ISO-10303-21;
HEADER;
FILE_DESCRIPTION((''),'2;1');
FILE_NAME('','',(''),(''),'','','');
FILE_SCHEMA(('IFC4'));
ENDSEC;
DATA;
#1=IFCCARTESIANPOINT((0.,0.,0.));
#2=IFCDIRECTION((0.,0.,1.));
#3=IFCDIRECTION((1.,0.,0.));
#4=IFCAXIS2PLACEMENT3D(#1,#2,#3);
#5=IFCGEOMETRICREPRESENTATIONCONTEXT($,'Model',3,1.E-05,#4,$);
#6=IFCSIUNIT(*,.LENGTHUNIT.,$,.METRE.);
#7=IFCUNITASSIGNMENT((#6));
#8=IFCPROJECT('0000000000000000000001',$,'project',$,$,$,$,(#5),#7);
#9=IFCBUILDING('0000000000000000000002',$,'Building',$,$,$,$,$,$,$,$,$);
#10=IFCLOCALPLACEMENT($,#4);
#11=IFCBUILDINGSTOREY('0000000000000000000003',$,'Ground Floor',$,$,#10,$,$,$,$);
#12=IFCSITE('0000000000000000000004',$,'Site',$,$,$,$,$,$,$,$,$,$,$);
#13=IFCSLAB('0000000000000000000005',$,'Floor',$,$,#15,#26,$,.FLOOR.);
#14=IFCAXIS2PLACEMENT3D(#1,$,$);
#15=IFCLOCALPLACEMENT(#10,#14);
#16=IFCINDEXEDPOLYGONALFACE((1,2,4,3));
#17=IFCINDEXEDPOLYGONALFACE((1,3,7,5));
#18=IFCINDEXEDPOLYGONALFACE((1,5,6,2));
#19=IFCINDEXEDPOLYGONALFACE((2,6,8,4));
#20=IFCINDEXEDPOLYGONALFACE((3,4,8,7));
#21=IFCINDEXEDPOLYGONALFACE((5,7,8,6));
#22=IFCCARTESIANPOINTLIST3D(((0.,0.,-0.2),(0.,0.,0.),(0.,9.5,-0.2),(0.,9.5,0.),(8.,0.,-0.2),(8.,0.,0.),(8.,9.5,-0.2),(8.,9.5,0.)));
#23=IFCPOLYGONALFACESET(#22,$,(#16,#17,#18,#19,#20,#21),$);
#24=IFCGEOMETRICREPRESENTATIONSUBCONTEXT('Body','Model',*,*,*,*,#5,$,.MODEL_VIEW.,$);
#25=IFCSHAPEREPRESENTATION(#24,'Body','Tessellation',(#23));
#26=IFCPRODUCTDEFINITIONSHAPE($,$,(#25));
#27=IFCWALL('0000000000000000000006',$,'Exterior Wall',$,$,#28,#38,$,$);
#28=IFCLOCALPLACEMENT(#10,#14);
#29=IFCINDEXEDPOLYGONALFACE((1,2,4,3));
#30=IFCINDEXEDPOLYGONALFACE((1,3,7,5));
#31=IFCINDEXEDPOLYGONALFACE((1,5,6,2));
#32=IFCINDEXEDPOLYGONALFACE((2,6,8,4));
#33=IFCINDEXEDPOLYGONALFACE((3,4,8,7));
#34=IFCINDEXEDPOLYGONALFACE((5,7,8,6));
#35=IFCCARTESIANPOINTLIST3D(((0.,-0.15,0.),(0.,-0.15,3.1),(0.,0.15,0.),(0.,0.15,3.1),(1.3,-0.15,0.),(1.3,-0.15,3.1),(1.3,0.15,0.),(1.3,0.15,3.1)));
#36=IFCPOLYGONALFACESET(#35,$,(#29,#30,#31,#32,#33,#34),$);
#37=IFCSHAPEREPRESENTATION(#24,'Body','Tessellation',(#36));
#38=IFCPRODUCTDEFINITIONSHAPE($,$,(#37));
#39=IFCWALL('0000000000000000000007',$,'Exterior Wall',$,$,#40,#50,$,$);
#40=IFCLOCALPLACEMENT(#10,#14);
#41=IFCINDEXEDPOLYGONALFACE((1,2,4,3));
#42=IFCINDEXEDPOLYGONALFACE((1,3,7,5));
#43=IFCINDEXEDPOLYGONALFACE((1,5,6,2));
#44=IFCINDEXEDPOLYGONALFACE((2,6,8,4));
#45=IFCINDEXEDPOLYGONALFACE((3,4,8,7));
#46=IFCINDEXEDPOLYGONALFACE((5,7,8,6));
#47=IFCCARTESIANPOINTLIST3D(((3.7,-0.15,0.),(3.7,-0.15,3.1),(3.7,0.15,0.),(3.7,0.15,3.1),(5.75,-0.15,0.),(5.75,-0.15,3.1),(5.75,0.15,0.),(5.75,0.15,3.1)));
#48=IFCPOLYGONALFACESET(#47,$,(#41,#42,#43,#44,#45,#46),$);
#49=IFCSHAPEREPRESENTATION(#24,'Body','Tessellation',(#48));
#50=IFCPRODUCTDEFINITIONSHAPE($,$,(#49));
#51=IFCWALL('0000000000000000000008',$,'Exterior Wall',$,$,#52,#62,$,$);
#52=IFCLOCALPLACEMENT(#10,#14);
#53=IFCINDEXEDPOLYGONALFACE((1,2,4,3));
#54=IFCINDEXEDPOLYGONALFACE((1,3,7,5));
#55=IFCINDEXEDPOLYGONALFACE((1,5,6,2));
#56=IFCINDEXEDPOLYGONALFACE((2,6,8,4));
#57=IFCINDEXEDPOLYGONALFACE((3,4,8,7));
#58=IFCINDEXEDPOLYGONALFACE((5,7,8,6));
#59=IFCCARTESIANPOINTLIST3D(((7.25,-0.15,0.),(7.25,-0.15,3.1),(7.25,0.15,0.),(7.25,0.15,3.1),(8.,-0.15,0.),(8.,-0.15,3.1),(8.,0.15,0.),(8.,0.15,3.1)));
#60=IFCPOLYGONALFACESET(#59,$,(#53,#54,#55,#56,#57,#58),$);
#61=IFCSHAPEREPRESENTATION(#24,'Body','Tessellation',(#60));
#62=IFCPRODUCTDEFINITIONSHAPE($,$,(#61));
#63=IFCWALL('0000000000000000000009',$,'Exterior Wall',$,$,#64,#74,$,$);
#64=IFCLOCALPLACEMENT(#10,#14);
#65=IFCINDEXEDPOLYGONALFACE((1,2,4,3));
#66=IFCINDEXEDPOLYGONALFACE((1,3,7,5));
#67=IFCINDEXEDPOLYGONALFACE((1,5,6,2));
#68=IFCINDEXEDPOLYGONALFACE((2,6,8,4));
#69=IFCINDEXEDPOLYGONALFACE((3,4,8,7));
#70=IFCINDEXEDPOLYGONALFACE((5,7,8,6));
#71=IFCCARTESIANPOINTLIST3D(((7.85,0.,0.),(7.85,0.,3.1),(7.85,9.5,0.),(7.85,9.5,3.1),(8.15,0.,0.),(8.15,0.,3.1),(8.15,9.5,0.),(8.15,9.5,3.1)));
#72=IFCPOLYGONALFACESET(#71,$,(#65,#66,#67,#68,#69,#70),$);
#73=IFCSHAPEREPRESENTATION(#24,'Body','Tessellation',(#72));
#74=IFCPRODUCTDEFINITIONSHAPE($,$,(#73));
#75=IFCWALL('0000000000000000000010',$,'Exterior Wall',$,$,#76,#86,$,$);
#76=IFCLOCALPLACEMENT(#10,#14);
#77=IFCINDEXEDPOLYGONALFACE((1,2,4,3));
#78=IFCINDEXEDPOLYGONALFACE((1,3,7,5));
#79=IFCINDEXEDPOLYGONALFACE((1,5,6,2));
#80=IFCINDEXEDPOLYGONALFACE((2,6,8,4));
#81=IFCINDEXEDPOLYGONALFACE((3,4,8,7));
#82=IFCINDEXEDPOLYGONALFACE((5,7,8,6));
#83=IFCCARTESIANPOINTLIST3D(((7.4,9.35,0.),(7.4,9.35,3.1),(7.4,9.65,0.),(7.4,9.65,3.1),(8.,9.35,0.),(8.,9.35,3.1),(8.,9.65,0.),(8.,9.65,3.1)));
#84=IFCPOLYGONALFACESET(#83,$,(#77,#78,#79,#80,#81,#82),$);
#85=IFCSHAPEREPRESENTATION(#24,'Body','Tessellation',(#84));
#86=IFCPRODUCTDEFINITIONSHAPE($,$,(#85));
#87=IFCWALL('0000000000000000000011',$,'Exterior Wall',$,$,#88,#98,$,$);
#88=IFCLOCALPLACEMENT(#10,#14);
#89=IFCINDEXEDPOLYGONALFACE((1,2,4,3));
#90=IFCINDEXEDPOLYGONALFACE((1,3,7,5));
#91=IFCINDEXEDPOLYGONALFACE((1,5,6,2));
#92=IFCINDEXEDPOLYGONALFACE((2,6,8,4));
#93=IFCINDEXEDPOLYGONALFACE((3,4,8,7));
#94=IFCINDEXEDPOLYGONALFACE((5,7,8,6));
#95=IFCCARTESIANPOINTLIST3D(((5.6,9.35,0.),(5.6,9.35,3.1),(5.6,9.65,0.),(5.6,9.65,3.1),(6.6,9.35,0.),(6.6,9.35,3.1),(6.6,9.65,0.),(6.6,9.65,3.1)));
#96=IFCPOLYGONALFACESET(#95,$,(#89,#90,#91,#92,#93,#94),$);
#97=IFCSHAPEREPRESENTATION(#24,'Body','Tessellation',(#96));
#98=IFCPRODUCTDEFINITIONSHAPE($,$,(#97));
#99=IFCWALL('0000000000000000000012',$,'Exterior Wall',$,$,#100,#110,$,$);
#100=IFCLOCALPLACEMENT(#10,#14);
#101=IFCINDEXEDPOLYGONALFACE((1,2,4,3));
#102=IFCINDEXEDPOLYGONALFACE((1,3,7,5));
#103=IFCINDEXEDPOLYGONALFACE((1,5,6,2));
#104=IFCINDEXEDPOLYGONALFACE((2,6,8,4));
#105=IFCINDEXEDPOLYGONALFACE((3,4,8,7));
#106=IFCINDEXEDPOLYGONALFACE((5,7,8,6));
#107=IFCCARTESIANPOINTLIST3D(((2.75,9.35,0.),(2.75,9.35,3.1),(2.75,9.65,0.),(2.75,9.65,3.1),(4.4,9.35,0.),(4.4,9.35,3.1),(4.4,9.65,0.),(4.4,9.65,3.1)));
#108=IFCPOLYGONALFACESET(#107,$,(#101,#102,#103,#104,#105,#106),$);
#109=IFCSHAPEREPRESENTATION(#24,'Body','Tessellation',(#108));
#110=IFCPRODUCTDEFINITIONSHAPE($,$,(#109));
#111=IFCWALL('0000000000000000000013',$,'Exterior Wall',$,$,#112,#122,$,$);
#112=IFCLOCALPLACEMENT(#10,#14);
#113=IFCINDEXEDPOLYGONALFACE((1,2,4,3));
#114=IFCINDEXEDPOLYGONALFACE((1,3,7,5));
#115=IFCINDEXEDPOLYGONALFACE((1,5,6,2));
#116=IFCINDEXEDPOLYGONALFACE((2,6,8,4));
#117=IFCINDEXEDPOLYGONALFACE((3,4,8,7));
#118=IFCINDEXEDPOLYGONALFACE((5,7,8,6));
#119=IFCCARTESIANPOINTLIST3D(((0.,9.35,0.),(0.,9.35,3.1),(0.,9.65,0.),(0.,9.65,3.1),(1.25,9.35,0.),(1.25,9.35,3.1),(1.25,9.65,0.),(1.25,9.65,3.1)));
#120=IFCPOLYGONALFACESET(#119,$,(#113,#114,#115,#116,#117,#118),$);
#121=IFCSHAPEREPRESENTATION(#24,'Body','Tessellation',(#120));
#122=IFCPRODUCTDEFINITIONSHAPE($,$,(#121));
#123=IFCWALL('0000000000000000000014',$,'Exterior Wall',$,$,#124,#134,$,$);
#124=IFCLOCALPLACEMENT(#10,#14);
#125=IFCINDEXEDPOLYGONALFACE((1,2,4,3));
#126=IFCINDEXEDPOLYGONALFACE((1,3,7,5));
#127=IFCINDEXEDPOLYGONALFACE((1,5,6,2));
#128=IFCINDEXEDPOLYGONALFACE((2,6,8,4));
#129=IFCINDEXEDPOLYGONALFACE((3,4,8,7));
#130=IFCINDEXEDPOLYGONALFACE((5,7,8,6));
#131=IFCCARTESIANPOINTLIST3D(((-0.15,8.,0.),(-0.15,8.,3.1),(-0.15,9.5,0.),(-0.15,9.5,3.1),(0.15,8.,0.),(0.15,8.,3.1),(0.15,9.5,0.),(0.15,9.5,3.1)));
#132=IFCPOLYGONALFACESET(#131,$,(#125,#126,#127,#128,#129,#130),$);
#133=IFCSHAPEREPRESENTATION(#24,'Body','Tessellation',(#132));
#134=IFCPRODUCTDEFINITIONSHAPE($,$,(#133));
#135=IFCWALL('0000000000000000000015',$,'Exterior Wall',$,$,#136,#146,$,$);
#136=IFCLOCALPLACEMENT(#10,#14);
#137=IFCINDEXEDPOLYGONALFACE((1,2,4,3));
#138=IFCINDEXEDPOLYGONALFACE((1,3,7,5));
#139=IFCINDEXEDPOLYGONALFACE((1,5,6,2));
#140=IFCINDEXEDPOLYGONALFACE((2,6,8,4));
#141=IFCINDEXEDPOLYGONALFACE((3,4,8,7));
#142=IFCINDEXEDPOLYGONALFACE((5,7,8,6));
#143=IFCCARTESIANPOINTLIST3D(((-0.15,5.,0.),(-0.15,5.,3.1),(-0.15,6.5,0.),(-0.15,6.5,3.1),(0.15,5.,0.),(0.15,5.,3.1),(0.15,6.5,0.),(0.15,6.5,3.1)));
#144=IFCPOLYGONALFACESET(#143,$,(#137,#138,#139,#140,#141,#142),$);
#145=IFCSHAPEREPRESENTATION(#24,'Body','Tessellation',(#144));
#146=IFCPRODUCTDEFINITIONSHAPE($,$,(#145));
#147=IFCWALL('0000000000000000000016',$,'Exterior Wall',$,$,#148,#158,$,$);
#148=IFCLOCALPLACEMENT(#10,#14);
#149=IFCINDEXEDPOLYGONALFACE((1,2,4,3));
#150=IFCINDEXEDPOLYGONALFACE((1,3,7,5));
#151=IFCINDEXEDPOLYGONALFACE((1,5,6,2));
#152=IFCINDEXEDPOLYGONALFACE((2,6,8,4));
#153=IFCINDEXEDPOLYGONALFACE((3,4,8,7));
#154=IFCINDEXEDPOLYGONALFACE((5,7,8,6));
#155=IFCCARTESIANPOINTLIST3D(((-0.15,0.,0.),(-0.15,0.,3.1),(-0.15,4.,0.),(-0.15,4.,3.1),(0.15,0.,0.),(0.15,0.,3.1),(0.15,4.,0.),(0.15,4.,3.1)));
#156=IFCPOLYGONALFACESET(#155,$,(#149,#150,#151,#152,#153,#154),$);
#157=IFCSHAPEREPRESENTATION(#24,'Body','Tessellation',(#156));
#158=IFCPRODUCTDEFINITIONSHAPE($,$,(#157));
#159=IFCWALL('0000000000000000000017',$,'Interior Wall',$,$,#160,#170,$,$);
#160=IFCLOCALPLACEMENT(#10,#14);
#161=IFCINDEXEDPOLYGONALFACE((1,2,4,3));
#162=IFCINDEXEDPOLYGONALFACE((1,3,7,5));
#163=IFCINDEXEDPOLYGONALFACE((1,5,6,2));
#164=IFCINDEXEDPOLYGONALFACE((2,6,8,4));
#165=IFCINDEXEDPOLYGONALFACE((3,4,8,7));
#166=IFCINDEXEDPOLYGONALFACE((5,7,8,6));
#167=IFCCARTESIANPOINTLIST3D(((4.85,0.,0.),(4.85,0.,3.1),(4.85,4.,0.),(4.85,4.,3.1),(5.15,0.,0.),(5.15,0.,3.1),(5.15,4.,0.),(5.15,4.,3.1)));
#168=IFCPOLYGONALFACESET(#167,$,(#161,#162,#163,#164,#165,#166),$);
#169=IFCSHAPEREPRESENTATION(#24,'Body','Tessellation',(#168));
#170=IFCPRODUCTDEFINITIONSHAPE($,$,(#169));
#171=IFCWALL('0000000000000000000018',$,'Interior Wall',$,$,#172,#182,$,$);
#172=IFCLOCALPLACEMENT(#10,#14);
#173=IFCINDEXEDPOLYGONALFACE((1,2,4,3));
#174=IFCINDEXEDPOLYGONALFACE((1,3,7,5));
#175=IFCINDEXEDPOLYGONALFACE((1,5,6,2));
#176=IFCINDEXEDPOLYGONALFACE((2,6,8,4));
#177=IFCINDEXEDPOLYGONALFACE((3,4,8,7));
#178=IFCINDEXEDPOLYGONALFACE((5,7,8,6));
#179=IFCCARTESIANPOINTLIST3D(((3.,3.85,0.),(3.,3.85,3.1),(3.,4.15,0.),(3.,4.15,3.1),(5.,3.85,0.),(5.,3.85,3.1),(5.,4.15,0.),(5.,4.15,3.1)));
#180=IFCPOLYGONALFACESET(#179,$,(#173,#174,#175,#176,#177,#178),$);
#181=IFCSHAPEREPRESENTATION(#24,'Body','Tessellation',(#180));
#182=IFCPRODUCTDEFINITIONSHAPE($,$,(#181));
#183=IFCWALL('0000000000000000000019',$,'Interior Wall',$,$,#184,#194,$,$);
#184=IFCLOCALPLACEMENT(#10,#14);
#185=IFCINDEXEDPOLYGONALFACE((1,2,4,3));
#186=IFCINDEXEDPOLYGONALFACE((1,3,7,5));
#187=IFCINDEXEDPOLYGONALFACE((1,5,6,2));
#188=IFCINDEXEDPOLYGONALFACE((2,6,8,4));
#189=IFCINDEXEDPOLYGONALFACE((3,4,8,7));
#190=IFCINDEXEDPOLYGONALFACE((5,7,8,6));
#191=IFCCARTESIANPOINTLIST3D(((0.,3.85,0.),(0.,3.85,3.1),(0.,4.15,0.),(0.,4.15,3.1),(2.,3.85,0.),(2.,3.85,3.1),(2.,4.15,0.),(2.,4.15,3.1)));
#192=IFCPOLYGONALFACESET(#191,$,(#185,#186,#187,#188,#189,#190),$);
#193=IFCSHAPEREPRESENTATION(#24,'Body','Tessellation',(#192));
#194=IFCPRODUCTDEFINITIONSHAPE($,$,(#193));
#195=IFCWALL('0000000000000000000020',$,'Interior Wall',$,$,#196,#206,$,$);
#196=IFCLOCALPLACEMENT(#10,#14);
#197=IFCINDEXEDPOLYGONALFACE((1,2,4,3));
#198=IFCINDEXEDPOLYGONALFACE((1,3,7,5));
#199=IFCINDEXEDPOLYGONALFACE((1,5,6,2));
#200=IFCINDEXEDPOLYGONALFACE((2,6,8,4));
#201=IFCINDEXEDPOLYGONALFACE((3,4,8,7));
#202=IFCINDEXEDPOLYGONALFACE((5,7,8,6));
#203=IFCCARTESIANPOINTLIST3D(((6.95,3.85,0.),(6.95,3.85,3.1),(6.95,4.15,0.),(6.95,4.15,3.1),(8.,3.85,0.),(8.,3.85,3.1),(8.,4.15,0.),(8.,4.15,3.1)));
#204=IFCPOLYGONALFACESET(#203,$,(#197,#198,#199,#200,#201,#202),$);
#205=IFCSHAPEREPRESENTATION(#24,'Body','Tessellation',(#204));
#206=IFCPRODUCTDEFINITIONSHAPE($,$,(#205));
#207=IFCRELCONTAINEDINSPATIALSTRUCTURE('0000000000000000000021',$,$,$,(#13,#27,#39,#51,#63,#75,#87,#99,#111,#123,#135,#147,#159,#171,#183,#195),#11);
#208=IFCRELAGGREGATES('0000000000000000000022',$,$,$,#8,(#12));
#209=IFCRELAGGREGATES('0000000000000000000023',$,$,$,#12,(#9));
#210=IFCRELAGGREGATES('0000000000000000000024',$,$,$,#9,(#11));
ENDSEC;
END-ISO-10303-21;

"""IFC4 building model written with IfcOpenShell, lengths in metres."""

from ifc_helpers import new_model, si_unit, frame, origin_with_axes, place, context, subcontext, project, spatial, indexed_curve, outline, extrude, element, save


model = new_model("IFC4")

# Units and contexts
model_context = context("Model", 3, precision=1e-05, world=origin_with_axes())
body_context = subcontext(model_context, "Body", "Model", "MODEL_VIEW")
ifc_project = project(units=[si_unit("LENGTHUNIT", "METRE")], contexts=[model_context])

# Site, building, storey
site = spatial("IfcSite", under=ifc_project, Name="Site")
building = spatial("IfcBuilding", under=site, Name="Building")
storey_placement = place(None, origin_with_axes())
storey = spatial("IfcBuildingStorey", under=building, at=storey_placement, Name="Ground Floor")

# Slab
slab_placement = place(storey_placement, frame((0.0, 0.0, -0.2), z_axis=(0.0, 0.0, 1.0), x_axis=(1.0, 0.0, 0.0)))
element("IfcSlab", 1, at=slab_placement, inside=storey, Name="Floor", PredefinedType="FLOOR", context=body_context, shape_type="SweptSolid", body=[
    extrude(outline(indexed_curve([(0.0, 0.0), (8.0, 0.0), (8.0, 9.5), (0.0, 9.5)])), None, (0.0, 0.0, 1.0), 0.2),
])

# Walls
wall_1_placement = place(storey_placement, origin_with_axes())
element("IfcWall", 2, at=wall_1_placement, inside=storey, Name="Exterior Wall", context=body_context, shape_type="SweptSolid", body=[
    extrude(outline(indexed_curve([(0.0, 0.0), (0.0, 0.3), (1.3, 0.3), (1.3, 0.0), (0.0, 0.0)], self_intersect=False)), frame((0.0, -0.15, 0.0), z_axis=(0.0, 0.0, 1.0), x_axis=(1.0, 0.0, 0.0)), (0.0, 0.0, 1.0), 3.1),
])
wall_2_placement = place(storey_placement, frame((3.7, 0.0, 0.0), z_axis=(0.0, 0.0, 1.0), x_axis=(1.0, 0.0, 0.0)))
element("IfcWall", 3, at=wall_2_placement, inside=storey, Name="Exterior Wall", context=body_context, shape_type="SweptSolid", body=[
    extrude(outline(indexed_curve([(0.0, 0.0), (0.0, 0.3), (2.05, 0.3), (2.05, 0.0), (0.0, 0.0)], self_intersect=False)), frame((0.0, -0.15, 0.0), z_axis=(0.0, 0.0, 1.0), x_axis=(1.0, 0.0, 0.0)), (0.0, 0.0, 1.0), 3.1),
])
wall_3_placement = place(storey_placement, frame((7.25, 0.0, 0.0), z_axis=(0.0, 0.0, 1.0), x_axis=(1.0, 0.0, 0.0)))
element("IfcWall", 4, at=wall_3_placement, inside=storey, Name="Exterior Wall", context=body_context, shape_type="SweptSolid", body=[
    extrude(outline(indexed_curve([(0.0, 0.0), (0.0, 0.3), (0.75, 0.3), (0.75, 0.0), (0.0, 0.0)], self_intersect=False)), frame((0.0, -0.15, 0.0), z_axis=(0.0, 0.0, 1.0), x_axis=(1.0, 0.0, 0.0)), (0.0, 0.0, 1.0), 3.1),
])
wall_4_placement = place(storey_placement, frame((8.0, 0.0, 0.0), z_axis=(0.0, 0.0, 1.0), x_axis=(0.0, 1.0, 0.0)))
element("IfcWall", 5, at=wall_4_placement, inside=storey, Name="Exterior Wall", context=body_context, shape_type="SweptSolid", body=[
    extrude(outline(indexed_curve([(0.0, 0.0), (0.0, 0.3), (9.5, 0.3), (9.5, 0.0), (0.0, 0.0)], self_intersect=False)), frame((0.0, -0.15, 0.0), z_axis=(0.0, 0.0, 1.0), x_axis=(1.0, 0.0, 0.0)), (0.0, 0.0, 1.0), 3.1),
])
wall_5_placement = place(storey_placement, frame((8.0, 9.5, 0.0), z_axis=(0.0, 0.0, 1.0), x_axis=(-1.0, 0.0, 0.0)))
element("IfcWall", 6, at=wall_5_placement, inside=storey, Name="Exterior Wall", context=body_context, shape_type="SweptSolid", body=[
    extrude(outline(indexed_curve([(0.0, 0.0), (0.0, 0.3), (0.6, 0.3), (0.6, 0.0), (0.0, 0.0)], self_intersect=False)), frame((0.0, -0.15, 0.0), z_axis=(0.0, 0.0, 1.0), x_axis=(1.0, 0.0, 0.0)), (0.0, 0.0, 1.0), 3.1),
])
wall_6_placement = place(storey_placement, frame((6.6, 9.5, 0.0), z_axis=(0.0, 0.0, 1.0), x_axis=(-1.0, 0.0, 0.0)))
element("IfcWall", 7, at=wall_6_placement, inside=storey, Name="Exterior Wall", context=body_context, shape_type="SweptSolid", body=[
    extrude(outline(indexed_curve([(0.0, 0.0), (0.0, 0.3), (1.0, 0.3), (1.0, 0.0), (0.0, 0.0)], self_intersect=False)), frame((0.0, -0.15, 0.0), z_axis=(0.0, 0.0, 1.0), x_axis=(1.0, 0.0, 0.0)), (0.0, 0.0, 1.0), 3.1),
])
wall_7_placement = place(storey_placement, frame((4.4, 9.5, 0.0), z_axis=(0.0, 0.0, 1.0), x_axis=(-1.0, 0.0, 0.0)))
element("IfcWall", 8, at=wall_7_placement, inside=storey, Name="Exterior Wall", context=body_context, shape_type="SweptSolid", body=[
    extrude(outline(indexed_curve([(0.0, 0.0), (0.0, 0.3), (1.65, 0.3), (1.65, 0.0), (0.0, 0.0)], self_intersect=False)), frame((0.0, -0.15, 0.0), z_axis=(0.0, 0.0, 1.0), x_axis=(1.0, 0.0, 0.0)), (0.0, 0.0, 1.0), 3.1),
])
wall_8_placement = place(storey_placement, frame((1.25, 9.5, 0.0), z_axis=(0.0, 0.0, 1.0), x_axis=(-1.0, 0.0, 0.0)))
element("IfcWall", 9, at=wall_8_placement, inside=storey, Name="Exterior Wall", context=body_context, shape_type="SweptSolid", body=[
    extrude(outline(indexed_curve([(0.0, 0.0), (0.0, 0.3), (1.25, 0.3), (1.25, 0.0), (0.0, 0.0)], self_intersect=False)), frame((0.0, -0.15, 0.0), z_axis=(0.0, 0.0, 1.0), x_axis=(1.0, 0.0, 0.0)), (0.0, 0.0, 1.0), 3.1),
])
for number, where, z_axis, x_axis, name in (
    (10, (0.0, 9.5, 0.0), (0.0, 0.0, 1.0), (0.0, -1.0, 0.0), "Exterior Wall"),
    (11, (0.0, 6.5, 0.0), (0.0, 0.0, 1.0), (0.0, -1.0, 0.0), "Exterior Wall"),
):
    element("IfcWall", number, at=place(storey_placement, frame(where, z_axis=z_axis, x_axis=x_axis)), inside=storey, Name=name, context=body_context, shape_type="SweptSolid", body=[
        extrude(outline(indexed_curve([(0.0, 0.0), (0.0, 0.3), (1.5, 0.3), (1.5, 0.0), (0.0, 0.0)], self_intersect=False)), frame((0.0, -0.15, 0.0), z_axis=(0.0, 0.0, 1.0), x_axis=(1.0, 0.0, 0.0)), (0.0, 0.0, 1.0), 3.1),
    ])
for number, where, z_axis, x_axis, name in (
    (12, (0.0, 4.0, 0.0), (0.0, 0.0, 1.0), (0.0, -1.0, 0.0), "Exterior Wall"),
    (13, (5.0, 0.0, 0.0), (0.0, 0.0, 1.0), (0.0, 1.0, 0.0), "Interior Wall"),
):
    element("IfcWall", number, at=place(storey_placement, frame(where, z_axis=z_axis, x_axis=x_axis)), inside=storey, Name=name, context=body_context, shape_type="SweptSolid", body=[
        extrude(outline(indexed_curve([(0.0, 0.0), (0.0, 0.3), (4.0, 0.3), (4.0, 0.0), (0.0, 0.0)], self_intersect=False)), frame((0.0, -0.15, 0.0), z_axis=(0.0, 0.0, 1.0), x_axis=(1.0, 0.0, 0.0)), (0.0, 0.0, 1.0), 3.1),
    ])
for number, where, z_axis, x_axis, name in (
    (14, (5.0, 4.0, 0.0), (0.0, 0.0, 1.0), (-1.0, 0.0, 0.0), "Interior Wall"),
    (15, (2.0, 4.0, 0.0), (0.0, 0.0, 1.0), (-1.0, 0.0, 0.0), "Interior Wall"),
):
    element("IfcWall", number, at=place(storey_placement, frame(where, z_axis=z_axis, x_axis=x_axis)), inside=storey, Name=name, context=body_context, shape_type="SweptSolid", body=[
        extrude(outline(indexed_curve([(0.0, 0.0), (0.0, 0.3), (2.0, 0.3), (2.0, 0.0), (0.0, 0.0)], self_intersect=False)), frame((0.0, -0.15, 0.0), z_axis=(0.0, 0.0, 1.0), x_axis=(1.0, 0.0, 0.0)), (0.0, 0.0, 1.0), 3.1),
    ])
for number, where, z_axis, x_axis, name in (
    (16, (8.0, 4.0, 0.0), (0.0, 0.0, 1.0), (-1.0, 0.0, 0.0), "Interior Wall"),
):
    element("IfcWall", number, at=place(storey_placement, frame(where, z_axis=z_axis, x_axis=x_axis)), inside=storey, Name=name, context=body_context, shape_type="SweptSolid", body=[
        extrude(outline(indexed_curve([(0.0, 0.0), (0.0, 0.3), (1.05, 0.3), (1.05, 0.0), (0.0, 0.0)], self_intersect=False)), frame((0.0, -0.15, 0.0), z_axis=(0.0, 0.0, 1.0), x_axis=(1.0, 0.0, 0.0)), (0.0, 0.0, 1.0), 3.1),
    ])

save(model, "model.ifc")
